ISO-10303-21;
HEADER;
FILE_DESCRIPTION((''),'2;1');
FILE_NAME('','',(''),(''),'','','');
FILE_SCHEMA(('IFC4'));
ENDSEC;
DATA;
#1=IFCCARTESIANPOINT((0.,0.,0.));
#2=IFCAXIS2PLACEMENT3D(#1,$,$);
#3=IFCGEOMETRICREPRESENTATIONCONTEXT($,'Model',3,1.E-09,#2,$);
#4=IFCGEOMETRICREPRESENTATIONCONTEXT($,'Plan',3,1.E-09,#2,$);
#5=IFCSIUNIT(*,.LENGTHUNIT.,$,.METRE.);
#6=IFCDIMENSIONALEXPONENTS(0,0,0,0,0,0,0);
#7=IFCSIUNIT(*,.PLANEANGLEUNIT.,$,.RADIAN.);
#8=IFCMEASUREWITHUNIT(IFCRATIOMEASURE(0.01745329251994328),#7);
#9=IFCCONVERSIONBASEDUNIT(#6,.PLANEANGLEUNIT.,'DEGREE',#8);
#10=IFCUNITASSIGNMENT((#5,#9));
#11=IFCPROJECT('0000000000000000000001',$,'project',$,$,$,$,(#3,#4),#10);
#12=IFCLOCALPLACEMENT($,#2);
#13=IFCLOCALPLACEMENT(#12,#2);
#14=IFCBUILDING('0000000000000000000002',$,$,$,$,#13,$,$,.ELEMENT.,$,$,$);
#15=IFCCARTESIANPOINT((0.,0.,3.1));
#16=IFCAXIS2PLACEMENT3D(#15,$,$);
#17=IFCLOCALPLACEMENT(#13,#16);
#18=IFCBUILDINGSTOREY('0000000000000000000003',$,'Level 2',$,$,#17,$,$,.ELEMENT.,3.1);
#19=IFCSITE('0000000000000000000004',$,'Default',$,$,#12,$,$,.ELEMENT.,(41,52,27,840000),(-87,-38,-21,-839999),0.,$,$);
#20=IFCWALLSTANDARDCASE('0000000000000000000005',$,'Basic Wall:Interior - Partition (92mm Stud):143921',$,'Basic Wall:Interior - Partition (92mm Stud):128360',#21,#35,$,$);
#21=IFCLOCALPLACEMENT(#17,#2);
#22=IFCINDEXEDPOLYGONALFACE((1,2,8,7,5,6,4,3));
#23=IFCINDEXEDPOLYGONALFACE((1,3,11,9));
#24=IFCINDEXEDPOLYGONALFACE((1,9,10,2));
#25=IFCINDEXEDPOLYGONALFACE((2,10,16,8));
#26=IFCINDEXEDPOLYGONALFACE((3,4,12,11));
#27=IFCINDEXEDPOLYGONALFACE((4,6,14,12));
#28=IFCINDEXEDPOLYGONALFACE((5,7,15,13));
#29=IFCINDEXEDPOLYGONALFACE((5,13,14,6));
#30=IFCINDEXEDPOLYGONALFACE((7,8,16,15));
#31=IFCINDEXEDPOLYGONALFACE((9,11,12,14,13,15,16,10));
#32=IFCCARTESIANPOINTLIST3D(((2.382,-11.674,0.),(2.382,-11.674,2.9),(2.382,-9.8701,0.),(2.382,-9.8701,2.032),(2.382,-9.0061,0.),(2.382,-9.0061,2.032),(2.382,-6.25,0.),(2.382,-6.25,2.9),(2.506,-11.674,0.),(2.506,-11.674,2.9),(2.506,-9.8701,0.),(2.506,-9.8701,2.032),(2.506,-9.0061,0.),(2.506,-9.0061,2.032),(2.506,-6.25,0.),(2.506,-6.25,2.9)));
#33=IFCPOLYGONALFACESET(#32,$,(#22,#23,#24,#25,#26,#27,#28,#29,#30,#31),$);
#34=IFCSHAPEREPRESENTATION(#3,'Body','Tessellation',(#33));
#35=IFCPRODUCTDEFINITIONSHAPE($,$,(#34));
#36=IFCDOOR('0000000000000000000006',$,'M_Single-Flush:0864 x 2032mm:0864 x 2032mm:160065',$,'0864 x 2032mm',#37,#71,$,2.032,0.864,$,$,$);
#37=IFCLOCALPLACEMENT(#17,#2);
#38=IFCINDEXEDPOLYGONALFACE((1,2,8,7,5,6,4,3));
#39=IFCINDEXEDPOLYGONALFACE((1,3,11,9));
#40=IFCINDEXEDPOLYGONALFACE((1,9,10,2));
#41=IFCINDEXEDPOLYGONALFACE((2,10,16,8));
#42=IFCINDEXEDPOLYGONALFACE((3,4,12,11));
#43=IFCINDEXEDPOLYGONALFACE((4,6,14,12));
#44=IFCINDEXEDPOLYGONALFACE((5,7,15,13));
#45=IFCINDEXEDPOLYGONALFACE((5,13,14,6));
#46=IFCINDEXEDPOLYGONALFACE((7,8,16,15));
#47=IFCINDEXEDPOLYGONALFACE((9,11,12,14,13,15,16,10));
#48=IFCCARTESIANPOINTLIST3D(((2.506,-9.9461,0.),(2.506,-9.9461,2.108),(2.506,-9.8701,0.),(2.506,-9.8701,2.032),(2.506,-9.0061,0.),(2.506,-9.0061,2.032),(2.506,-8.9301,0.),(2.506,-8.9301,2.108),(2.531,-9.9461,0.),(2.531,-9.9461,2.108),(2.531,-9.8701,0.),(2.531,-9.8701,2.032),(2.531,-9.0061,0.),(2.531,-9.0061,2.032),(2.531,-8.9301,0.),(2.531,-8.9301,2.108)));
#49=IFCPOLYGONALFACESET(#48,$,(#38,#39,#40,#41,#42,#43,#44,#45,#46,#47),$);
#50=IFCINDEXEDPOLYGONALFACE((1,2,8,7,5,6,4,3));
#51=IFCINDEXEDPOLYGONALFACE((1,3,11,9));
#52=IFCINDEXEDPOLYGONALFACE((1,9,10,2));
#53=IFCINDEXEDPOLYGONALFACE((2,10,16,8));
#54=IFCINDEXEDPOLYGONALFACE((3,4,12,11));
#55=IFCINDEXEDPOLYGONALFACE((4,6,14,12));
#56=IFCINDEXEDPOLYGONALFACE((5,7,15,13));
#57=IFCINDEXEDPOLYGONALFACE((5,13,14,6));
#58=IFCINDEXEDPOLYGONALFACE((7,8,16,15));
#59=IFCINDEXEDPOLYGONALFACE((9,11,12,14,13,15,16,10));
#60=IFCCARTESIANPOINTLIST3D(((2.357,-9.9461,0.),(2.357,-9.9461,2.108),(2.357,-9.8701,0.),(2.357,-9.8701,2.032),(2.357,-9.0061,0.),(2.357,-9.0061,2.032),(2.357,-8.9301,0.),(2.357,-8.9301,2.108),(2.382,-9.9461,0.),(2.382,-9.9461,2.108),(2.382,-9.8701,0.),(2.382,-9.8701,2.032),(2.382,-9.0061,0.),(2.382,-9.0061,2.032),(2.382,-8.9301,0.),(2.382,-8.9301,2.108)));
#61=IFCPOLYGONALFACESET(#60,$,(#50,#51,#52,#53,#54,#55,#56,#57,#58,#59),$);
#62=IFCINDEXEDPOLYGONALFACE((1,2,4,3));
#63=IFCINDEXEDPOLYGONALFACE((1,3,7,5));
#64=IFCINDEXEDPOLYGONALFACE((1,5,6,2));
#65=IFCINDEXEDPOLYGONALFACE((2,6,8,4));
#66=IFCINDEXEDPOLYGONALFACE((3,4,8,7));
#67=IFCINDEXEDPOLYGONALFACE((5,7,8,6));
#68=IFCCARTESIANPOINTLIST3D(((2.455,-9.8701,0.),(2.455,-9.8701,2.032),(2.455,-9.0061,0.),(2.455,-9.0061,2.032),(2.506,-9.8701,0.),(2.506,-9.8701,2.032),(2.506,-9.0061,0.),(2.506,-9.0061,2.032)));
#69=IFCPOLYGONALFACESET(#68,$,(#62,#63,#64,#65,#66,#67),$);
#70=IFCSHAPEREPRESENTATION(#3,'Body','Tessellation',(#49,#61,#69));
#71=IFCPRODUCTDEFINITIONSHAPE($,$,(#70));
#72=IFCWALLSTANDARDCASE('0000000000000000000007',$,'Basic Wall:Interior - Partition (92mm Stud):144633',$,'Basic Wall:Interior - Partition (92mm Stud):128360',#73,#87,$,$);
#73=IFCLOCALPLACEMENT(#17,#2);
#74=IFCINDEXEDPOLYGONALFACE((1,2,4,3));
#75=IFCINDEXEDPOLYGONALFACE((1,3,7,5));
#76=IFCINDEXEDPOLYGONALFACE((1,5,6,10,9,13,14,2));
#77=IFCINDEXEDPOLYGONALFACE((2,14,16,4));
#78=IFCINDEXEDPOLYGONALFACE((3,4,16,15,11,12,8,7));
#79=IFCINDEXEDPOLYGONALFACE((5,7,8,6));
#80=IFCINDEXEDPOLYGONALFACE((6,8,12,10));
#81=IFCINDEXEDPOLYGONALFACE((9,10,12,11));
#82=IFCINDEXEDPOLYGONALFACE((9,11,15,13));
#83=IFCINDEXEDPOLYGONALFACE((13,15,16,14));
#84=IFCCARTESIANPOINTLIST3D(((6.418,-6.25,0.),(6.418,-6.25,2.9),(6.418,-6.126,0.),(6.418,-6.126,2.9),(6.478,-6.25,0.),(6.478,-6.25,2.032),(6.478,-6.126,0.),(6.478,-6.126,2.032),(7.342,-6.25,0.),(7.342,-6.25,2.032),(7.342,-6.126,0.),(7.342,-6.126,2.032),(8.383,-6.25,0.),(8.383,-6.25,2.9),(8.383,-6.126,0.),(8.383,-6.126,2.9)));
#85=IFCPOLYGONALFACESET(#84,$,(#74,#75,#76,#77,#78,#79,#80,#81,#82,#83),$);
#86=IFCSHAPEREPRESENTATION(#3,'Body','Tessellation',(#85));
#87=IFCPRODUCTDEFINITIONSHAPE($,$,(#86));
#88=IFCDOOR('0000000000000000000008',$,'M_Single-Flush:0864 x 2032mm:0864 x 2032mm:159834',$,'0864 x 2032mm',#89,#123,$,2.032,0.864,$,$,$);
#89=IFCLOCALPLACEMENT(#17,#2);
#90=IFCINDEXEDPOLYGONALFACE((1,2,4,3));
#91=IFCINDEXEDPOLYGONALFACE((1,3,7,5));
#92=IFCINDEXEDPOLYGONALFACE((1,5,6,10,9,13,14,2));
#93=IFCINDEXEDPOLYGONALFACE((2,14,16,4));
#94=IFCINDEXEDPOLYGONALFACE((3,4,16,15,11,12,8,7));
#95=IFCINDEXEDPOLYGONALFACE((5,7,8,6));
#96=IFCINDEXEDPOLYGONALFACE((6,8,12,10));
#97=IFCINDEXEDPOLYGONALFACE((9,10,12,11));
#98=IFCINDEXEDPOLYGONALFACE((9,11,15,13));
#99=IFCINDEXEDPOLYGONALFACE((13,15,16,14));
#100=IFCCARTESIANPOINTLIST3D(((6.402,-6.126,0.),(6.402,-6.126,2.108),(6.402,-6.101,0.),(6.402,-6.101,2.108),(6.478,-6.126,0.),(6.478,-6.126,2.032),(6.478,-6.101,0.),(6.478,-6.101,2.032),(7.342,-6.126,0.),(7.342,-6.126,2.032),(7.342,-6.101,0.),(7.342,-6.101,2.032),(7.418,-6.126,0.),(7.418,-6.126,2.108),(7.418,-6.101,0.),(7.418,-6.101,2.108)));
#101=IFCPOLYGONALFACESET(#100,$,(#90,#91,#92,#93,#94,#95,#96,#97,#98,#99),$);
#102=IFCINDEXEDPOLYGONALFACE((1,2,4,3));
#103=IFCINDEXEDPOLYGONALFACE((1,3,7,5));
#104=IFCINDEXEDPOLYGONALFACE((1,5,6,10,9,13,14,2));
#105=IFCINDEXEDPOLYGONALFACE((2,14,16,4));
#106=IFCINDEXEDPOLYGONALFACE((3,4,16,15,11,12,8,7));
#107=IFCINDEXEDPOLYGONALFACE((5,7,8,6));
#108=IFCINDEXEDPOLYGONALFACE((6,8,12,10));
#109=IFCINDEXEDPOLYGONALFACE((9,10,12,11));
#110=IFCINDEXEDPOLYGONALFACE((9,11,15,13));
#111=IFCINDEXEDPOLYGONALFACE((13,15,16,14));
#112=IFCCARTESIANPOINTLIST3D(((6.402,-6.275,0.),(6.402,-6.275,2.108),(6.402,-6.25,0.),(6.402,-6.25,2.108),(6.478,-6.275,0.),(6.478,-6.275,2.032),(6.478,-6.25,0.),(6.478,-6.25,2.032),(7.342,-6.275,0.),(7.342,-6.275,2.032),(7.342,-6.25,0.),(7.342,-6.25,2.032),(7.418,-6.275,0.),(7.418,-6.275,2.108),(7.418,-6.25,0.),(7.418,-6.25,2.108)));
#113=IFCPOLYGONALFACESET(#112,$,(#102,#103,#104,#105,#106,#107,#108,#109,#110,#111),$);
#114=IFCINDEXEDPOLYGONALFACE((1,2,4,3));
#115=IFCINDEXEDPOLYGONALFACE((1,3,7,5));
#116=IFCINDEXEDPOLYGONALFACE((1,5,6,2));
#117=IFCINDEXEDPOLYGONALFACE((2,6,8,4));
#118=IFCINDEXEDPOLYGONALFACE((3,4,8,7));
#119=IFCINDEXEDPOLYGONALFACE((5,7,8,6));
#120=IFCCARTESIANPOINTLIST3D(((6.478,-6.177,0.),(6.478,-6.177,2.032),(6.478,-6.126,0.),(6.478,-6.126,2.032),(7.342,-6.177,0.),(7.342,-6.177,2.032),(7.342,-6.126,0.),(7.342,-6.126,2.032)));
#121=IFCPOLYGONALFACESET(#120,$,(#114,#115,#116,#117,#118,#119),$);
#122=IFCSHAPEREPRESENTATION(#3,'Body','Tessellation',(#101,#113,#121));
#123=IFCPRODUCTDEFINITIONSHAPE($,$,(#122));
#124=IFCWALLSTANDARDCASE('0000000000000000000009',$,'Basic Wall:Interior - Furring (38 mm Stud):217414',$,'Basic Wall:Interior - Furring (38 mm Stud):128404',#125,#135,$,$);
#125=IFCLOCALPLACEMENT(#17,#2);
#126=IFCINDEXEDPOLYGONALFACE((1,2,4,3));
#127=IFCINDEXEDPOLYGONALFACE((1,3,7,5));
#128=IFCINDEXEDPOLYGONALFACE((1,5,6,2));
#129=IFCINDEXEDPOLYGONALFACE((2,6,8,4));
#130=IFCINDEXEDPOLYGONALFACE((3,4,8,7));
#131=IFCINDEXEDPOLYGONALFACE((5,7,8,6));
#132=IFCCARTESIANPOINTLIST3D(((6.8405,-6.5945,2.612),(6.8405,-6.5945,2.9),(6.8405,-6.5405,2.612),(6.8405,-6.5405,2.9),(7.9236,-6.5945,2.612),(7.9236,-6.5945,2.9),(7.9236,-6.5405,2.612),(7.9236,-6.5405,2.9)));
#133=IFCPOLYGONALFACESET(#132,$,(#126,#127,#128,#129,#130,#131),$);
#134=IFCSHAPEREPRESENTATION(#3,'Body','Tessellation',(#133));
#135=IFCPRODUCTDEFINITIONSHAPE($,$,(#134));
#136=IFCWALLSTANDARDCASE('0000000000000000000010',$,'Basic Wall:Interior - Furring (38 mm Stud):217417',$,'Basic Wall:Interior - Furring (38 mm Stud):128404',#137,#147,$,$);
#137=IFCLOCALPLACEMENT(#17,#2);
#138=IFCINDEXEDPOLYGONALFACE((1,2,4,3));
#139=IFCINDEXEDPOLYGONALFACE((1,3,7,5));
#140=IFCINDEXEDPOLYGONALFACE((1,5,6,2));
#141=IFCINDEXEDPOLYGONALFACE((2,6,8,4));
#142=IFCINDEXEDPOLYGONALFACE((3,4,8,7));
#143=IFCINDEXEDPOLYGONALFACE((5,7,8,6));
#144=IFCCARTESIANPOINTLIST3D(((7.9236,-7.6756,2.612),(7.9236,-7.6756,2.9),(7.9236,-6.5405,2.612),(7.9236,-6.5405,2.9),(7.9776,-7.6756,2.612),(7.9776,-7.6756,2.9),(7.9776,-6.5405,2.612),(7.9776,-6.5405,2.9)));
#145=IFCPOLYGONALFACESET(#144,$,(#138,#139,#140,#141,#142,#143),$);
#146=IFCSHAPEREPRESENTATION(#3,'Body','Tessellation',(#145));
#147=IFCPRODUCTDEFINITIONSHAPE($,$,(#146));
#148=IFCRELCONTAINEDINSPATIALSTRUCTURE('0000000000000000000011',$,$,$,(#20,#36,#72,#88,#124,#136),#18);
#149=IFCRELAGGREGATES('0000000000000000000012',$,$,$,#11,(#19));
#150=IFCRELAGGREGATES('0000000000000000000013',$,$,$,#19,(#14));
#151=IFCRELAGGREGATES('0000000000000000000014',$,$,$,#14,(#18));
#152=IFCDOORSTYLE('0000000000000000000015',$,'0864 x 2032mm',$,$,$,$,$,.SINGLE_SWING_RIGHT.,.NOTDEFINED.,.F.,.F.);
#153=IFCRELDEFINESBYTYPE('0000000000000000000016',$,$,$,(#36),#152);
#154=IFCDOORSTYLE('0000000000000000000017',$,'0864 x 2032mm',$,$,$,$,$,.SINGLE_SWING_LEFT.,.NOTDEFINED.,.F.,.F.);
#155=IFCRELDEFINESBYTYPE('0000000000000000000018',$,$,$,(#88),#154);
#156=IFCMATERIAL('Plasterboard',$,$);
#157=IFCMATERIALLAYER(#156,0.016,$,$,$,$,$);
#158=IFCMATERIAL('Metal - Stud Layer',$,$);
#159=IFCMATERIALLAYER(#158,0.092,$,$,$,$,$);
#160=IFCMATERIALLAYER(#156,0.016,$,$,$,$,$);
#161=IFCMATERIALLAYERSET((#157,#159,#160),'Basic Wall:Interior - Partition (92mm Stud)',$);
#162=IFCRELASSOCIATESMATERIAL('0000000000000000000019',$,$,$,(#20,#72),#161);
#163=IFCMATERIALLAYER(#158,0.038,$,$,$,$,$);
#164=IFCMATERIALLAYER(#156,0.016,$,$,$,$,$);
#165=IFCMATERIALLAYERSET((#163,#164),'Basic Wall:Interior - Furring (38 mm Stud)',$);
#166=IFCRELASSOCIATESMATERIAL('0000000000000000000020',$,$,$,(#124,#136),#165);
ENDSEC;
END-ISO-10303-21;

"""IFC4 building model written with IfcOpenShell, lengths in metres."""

from ifc_helpers import new_model, entity, si_unit, converted_unit, frame, frame_2d, origin, origin_2d_with_axis, place, context, project, spatial, polyline, rectangle, outline, extrude, source, transform, mapped, material, layer, layer_set, layer_usage, type_object, type_shapes, element, fill, save


model = new_model("IFC4")

# Units and contexts
model_context = context("Model", 3, precision=1e-09, world=origin())
plan_context = context("Plan", 3, precision=1e-09, world=origin())
ifc_project = project(units=[si_unit("LENGTHUNIT", "METRE"), converted_unit("PLANEANGLEUNIT", "DEGREE", entity("IfcRatioMeasure", 0.01745329251994328), si_unit("PLANEANGLEUNIT", "RADIAN"), dimensions=[0, 0, 0, 0, 0, 0, 0])], contexts=[model_context, plan_context])

# Site, building, storey
site_placement = place(None, origin())
site = spatial("IfcSite", under=ifc_project, at=site_placement, Name="Default", CompositionType="ELEMENT", RefLatitude=(41, 52, 27, 840000), RefLongitude=(-87, -38, -21, -839999), RefElevation=0.0)
building_placement = place(site_placement, origin())
building = spatial("IfcBuilding", under=site, at=building_placement, CompositionType="ELEMENT")
storey_placement = place(building_placement, frame((0.0, 0.0, 3.1)))
storey = spatial("IfcBuildingStorey", under=building, at=storey_placement, Name="Level 2", CompositionType="ELEMENT", Elevation=3.1)

# Shared definitions
ifc_material_1 = material(Name="Metal - Stud Layer")
ifc_material_2 = material(Name="Plasterboard")

# Walls, openings, doors
ifc_layer_1 = layer(ifc_material_2, 0.016)
ifc_layer_2 = layer(ifc_material_1, 0.092)
ifc_layer_3 = layer(ifc_material_2, 0.016)
ifc_layer_set_1 = layer_set([ifc_layer_1, ifc_layer_2, ifc_layer_3], Name="Basic Wall:Interior - Partition (92mm Stud)")
ifc_layer_usage_1 = layer_usage(ifc_layer_set_1, "AXIS2", "NEGATIVE", 0.062)
wall_1_placement = place(storey_placement, frame((2.444, -6.25, 0.0), z_axis=(0.0, 0.0, 1.0), x_axis=(0.0, -1.0, 0.0)))
wall_1 = element("IfcWallStandardCase", 1, at=wall_1_placement, inside=storey, material=ifc_layer_usage_1, Name="Basic Wall:Interior - Partition (92mm Stud):143921", ObjectType="Basic Wall:Interior - Partition (92mm Stud):128360", context=model_context, shape_type="SweptSolid", body=[
    extrude(rectangle(XDim=5.424, YDim=0.124, at=frame_2d((2.712, 0.0), x_axis=(-1.0, 0.0))), origin(), (0.0, 0.0, 1.0), 2.9),
])
opening_1_placement = place(wall_1_placement, frame((2.7561, -0.062, 0.0)))
opening_1 = element("IfcOpeningElement", 2, at=opening_1_placement, cuts=wall_1, ObjectType="Opening", context=model_context, shape_type="SweptSolid", body=[
    extrude(rectangle(XDim=0.864, YDim=2.032, at=frame_2d((1.016, 0.432), x_axis=(0.0, 1.0))), frame((0.0, 0.0, 0.0), z_axis=(0.0, 1.0, 0.0), x_axis=(0.0, 0.0, 1.0)), (0.0, 0.0, 1.0), 0.124),
])
door_style_1 = type_object("IfcDoorStyle", Name="0864 x 2032mm", ConstructionType="NOTDEFINED", OperationType="SINGLE_SWING_RIGHT", ParameterTakesPrecedence=False, Sizeable=False)
shared_shape_1 = source(origin(), model_context, "Body", "SweptSolid", [
    extrude(outline(polyline([(-0.508, -1.073), (0.508, -1.073), (0.508, 1.035), (0.432, 1.035), (0.432, -0.997), (-0.432, -0.997), (-0.432, 1.035), (-0.508, 1.035), (-0.508, -1.073)])), frame((0.432, 0.124, 1.035), z_axis=(0.0, 1.0, 0.0), x_axis=(1.0, 0.0, 0.0)), (0.0, 0.0, 1.0), 0.025),
    extrude(outline(polyline([(-1.073, -0.508), (1.035, -0.508), (1.035, -0.432), (-0.997, -0.432), (-0.997, 0.432), (1.035, 0.432), (1.035, 0.508), (-1.073, 0.508), (-1.073, -0.508)])), frame((0.432, -0.025, 1.035), z_axis=(0.0, 1.0, 0.0), x_axis=(0.0, 0.0, -1.0)), (0.0, 0.0, 1.0), 0.025),
    extrude(rectangle(XDim=0.051, YDim=0.864, at=origin_2d_with_axis()), frame((0.432, 0.0985, 0.0), z_axis=(0.0, 0.0, 1.0), x_axis=(0.0, 1.0, 0.0)), (0.0, 0.0, 1.0), 2.032),
])
type_shapes(door_style_1, [shared_shape_1])
door_1_placement = place(opening_1_placement, origin())
door_1 = element("IfcDoor", 3, at=door_1_placement, inside=storey, type_object=door_style_1, Name="M_Single-Flush:0864 x 2032mm:0864 x 2032mm:160065", ObjectType="0864 x 2032mm", OverallHeight=2.032, OverallWidth=0.864, context=model_context, shape_type="MappedRepresentation", body=[
    mapped(shared_shape_1, transform((0.0, 0.0, 0.0), scale=1.0)),
])
fill(opening_1, door_1)
ifc_layer_usage_2 = layer_usage(ifc_layer_set_1, "AXIS2", "NEGATIVE", 0.062)
wall_2_placement = place(storey_placement, frame((6.418, -6.188, 0.0)))
wall_2 = element("IfcWallStandardCase", 4, at=wall_2_placement, inside=storey, material=ifc_layer_usage_2, Name="Basic Wall:Interior - Partition (92mm Stud):144633", ObjectType="Basic Wall:Interior - Partition (92mm Stud):128360", context=model_context, shape_type="SweptSolid", body=[
    extrude(rectangle(XDim=1.965, YDim=0.124, at=frame_2d((0.9825, 0.0), x_axis=(-1.0, 0.0))), origin(), (0.0, 0.0, 1.0), 2.9),
])
opening_2_placement = place(wall_2_placement, frame((0.06, -0.062, 0.0)))
opening_2 = element("IfcOpeningElement", 5, at=opening_2_placement, cuts=wall_2, ObjectType="Opening", context=model_context, shape_type="SweptSolid", body=[
    extrude(rectangle(XDim=0.864, YDim=2.032, at=frame_2d((1.016, 0.432), x_axis=(0.0, -1.0))), frame((0.0, 0.0, 0.0), z_axis=(0.0, 1.0, 0.0), x_axis=(0.0, 0.0, 1.0)), (0.0, 0.0, 1.0), 0.124),
])
door_style_2 = type_object("IfcDoorStyle", Name="0864 x 2032mm", ConstructionType="NOTDEFINED", OperationType="SINGLE_SWING_LEFT", ParameterTakesPrecedence=False, Sizeable=False)
shared_shape_2 = source(origin(), model_context, "Body", "SweptSolid", [
    extrude(outline(polyline([(-0.508, -1.073), (0.508, -1.073), (0.508, 1.035), (0.432, 1.035), (0.432, -0.997), (-0.432, -0.997), (-0.432, 1.035), (-0.508, 1.035), (-0.508, -1.073)])), frame((0.432, 0.149, 1.035), z_axis=(0.0, -1.0, 0.0), x_axis=(-1.0, 0.0, 0.0)), (0.0, 0.0, 1.0), 0.025),
    extrude(outline(polyline([(-1.073, -0.508), (1.035, -0.508), (1.035, -0.432), (-0.997, -0.432), (-0.997, 0.432), (1.035, 0.432), (1.035, 0.508), (-1.073, 0.508), (-1.073, -0.508)])), frame((0.432, 0.0, 1.035), z_axis=(0.0, -1.0, 0.0), x_axis=(0.0, 0.0, -1.0)), (0.0, 0.0, 1.0), 0.025),
    extrude(rectangle(XDim=0.864, YDim=0.051, at=origin_2d_with_axis()), frame((0.432, 0.0985, 0.0)), (0.0, 0.0, 1.0), 2.032),
])
type_shapes(door_style_2, [shared_shape_2])
door_2_placement = place(opening_2_placement, origin())
door_2 = element("IfcDoor", 6, at=door_2_placement, inside=storey, type_object=door_style_2, Name="M_Single-Flush:0864 x 2032mm:0864 x 2032mm:159834", ObjectType="0864 x 2032mm", OverallHeight=2.032, OverallWidth=0.864, context=model_context, shape_type="MappedRepresentation", body=[
    mapped(shared_shape_2, transform((0.0, 0.0, 0.0), scale=1.0)),
])
fill(opening_2, door_2)

# Walls
ifc_layer_4 = layer(ifc_material_1, 0.038)
ifc_layer_5 = layer(ifc_material_2, 0.016)
ifc_layer_set_2 = layer_set([ifc_layer_4, ifc_layer_5], Name="Basic Wall:Interior - Furring (38 mm Stud)")
ifc_layer_usage_3 = layer_usage(ifc_layer_set_2, "AXIS2", "NEGATIVE", 0.027)
wall_3_placement = place(storey_placement, frame((6.8405, -6.5675, 2.612)))
element("IfcWallStandardCase", 7, at=wall_3_placement, inside=storey, material=ifc_layer_usage_3, Name="Basic Wall:Interior - Furring (38 mm Stud):217414", ObjectType="Basic Wall:Interior - Furring (38 mm Stud):128404", context=model_context, shape_type="SweptSolid", body=[
    extrude(rectangle(XDim=1.0831, YDim=0.054, at=frame_2d((0.5416, 0.0), x_axis=(-1.0, 0.0))), origin(), (0.0, 0.0, 1.0), 0.288),
])
ifc_layer_usage_4 = layer_usage(ifc_layer_set_2, "AXIS2", "NEGATIVE", 0.027)
wall_4_placement = place(storey_placement, frame((7.9506, -6.5405, 2.612), z_axis=(0.0, 0.0, 1.0), x_axis=(0.0, -1.0, 0.0)))
element("IfcWallStandardCase", 8, at=wall_4_placement, inside=storey, material=ifc_layer_usage_4, Name="Basic Wall:Interior - Furring (38 mm Stud):217417", ObjectType="Basic Wall:Interior - Furring (38 mm Stud):128404", context=model_context, shape_type="SweptSolid", body=[
    extrude(rectangle(XDim=1.1351, YDim=0.054, at=frame_2d((0.5675, 0.0), x_axis=(-1.0, 0.0))), origin(), (0.0, 0.0, 1.0), 0.288),
])

save(model, "model.ifc")
